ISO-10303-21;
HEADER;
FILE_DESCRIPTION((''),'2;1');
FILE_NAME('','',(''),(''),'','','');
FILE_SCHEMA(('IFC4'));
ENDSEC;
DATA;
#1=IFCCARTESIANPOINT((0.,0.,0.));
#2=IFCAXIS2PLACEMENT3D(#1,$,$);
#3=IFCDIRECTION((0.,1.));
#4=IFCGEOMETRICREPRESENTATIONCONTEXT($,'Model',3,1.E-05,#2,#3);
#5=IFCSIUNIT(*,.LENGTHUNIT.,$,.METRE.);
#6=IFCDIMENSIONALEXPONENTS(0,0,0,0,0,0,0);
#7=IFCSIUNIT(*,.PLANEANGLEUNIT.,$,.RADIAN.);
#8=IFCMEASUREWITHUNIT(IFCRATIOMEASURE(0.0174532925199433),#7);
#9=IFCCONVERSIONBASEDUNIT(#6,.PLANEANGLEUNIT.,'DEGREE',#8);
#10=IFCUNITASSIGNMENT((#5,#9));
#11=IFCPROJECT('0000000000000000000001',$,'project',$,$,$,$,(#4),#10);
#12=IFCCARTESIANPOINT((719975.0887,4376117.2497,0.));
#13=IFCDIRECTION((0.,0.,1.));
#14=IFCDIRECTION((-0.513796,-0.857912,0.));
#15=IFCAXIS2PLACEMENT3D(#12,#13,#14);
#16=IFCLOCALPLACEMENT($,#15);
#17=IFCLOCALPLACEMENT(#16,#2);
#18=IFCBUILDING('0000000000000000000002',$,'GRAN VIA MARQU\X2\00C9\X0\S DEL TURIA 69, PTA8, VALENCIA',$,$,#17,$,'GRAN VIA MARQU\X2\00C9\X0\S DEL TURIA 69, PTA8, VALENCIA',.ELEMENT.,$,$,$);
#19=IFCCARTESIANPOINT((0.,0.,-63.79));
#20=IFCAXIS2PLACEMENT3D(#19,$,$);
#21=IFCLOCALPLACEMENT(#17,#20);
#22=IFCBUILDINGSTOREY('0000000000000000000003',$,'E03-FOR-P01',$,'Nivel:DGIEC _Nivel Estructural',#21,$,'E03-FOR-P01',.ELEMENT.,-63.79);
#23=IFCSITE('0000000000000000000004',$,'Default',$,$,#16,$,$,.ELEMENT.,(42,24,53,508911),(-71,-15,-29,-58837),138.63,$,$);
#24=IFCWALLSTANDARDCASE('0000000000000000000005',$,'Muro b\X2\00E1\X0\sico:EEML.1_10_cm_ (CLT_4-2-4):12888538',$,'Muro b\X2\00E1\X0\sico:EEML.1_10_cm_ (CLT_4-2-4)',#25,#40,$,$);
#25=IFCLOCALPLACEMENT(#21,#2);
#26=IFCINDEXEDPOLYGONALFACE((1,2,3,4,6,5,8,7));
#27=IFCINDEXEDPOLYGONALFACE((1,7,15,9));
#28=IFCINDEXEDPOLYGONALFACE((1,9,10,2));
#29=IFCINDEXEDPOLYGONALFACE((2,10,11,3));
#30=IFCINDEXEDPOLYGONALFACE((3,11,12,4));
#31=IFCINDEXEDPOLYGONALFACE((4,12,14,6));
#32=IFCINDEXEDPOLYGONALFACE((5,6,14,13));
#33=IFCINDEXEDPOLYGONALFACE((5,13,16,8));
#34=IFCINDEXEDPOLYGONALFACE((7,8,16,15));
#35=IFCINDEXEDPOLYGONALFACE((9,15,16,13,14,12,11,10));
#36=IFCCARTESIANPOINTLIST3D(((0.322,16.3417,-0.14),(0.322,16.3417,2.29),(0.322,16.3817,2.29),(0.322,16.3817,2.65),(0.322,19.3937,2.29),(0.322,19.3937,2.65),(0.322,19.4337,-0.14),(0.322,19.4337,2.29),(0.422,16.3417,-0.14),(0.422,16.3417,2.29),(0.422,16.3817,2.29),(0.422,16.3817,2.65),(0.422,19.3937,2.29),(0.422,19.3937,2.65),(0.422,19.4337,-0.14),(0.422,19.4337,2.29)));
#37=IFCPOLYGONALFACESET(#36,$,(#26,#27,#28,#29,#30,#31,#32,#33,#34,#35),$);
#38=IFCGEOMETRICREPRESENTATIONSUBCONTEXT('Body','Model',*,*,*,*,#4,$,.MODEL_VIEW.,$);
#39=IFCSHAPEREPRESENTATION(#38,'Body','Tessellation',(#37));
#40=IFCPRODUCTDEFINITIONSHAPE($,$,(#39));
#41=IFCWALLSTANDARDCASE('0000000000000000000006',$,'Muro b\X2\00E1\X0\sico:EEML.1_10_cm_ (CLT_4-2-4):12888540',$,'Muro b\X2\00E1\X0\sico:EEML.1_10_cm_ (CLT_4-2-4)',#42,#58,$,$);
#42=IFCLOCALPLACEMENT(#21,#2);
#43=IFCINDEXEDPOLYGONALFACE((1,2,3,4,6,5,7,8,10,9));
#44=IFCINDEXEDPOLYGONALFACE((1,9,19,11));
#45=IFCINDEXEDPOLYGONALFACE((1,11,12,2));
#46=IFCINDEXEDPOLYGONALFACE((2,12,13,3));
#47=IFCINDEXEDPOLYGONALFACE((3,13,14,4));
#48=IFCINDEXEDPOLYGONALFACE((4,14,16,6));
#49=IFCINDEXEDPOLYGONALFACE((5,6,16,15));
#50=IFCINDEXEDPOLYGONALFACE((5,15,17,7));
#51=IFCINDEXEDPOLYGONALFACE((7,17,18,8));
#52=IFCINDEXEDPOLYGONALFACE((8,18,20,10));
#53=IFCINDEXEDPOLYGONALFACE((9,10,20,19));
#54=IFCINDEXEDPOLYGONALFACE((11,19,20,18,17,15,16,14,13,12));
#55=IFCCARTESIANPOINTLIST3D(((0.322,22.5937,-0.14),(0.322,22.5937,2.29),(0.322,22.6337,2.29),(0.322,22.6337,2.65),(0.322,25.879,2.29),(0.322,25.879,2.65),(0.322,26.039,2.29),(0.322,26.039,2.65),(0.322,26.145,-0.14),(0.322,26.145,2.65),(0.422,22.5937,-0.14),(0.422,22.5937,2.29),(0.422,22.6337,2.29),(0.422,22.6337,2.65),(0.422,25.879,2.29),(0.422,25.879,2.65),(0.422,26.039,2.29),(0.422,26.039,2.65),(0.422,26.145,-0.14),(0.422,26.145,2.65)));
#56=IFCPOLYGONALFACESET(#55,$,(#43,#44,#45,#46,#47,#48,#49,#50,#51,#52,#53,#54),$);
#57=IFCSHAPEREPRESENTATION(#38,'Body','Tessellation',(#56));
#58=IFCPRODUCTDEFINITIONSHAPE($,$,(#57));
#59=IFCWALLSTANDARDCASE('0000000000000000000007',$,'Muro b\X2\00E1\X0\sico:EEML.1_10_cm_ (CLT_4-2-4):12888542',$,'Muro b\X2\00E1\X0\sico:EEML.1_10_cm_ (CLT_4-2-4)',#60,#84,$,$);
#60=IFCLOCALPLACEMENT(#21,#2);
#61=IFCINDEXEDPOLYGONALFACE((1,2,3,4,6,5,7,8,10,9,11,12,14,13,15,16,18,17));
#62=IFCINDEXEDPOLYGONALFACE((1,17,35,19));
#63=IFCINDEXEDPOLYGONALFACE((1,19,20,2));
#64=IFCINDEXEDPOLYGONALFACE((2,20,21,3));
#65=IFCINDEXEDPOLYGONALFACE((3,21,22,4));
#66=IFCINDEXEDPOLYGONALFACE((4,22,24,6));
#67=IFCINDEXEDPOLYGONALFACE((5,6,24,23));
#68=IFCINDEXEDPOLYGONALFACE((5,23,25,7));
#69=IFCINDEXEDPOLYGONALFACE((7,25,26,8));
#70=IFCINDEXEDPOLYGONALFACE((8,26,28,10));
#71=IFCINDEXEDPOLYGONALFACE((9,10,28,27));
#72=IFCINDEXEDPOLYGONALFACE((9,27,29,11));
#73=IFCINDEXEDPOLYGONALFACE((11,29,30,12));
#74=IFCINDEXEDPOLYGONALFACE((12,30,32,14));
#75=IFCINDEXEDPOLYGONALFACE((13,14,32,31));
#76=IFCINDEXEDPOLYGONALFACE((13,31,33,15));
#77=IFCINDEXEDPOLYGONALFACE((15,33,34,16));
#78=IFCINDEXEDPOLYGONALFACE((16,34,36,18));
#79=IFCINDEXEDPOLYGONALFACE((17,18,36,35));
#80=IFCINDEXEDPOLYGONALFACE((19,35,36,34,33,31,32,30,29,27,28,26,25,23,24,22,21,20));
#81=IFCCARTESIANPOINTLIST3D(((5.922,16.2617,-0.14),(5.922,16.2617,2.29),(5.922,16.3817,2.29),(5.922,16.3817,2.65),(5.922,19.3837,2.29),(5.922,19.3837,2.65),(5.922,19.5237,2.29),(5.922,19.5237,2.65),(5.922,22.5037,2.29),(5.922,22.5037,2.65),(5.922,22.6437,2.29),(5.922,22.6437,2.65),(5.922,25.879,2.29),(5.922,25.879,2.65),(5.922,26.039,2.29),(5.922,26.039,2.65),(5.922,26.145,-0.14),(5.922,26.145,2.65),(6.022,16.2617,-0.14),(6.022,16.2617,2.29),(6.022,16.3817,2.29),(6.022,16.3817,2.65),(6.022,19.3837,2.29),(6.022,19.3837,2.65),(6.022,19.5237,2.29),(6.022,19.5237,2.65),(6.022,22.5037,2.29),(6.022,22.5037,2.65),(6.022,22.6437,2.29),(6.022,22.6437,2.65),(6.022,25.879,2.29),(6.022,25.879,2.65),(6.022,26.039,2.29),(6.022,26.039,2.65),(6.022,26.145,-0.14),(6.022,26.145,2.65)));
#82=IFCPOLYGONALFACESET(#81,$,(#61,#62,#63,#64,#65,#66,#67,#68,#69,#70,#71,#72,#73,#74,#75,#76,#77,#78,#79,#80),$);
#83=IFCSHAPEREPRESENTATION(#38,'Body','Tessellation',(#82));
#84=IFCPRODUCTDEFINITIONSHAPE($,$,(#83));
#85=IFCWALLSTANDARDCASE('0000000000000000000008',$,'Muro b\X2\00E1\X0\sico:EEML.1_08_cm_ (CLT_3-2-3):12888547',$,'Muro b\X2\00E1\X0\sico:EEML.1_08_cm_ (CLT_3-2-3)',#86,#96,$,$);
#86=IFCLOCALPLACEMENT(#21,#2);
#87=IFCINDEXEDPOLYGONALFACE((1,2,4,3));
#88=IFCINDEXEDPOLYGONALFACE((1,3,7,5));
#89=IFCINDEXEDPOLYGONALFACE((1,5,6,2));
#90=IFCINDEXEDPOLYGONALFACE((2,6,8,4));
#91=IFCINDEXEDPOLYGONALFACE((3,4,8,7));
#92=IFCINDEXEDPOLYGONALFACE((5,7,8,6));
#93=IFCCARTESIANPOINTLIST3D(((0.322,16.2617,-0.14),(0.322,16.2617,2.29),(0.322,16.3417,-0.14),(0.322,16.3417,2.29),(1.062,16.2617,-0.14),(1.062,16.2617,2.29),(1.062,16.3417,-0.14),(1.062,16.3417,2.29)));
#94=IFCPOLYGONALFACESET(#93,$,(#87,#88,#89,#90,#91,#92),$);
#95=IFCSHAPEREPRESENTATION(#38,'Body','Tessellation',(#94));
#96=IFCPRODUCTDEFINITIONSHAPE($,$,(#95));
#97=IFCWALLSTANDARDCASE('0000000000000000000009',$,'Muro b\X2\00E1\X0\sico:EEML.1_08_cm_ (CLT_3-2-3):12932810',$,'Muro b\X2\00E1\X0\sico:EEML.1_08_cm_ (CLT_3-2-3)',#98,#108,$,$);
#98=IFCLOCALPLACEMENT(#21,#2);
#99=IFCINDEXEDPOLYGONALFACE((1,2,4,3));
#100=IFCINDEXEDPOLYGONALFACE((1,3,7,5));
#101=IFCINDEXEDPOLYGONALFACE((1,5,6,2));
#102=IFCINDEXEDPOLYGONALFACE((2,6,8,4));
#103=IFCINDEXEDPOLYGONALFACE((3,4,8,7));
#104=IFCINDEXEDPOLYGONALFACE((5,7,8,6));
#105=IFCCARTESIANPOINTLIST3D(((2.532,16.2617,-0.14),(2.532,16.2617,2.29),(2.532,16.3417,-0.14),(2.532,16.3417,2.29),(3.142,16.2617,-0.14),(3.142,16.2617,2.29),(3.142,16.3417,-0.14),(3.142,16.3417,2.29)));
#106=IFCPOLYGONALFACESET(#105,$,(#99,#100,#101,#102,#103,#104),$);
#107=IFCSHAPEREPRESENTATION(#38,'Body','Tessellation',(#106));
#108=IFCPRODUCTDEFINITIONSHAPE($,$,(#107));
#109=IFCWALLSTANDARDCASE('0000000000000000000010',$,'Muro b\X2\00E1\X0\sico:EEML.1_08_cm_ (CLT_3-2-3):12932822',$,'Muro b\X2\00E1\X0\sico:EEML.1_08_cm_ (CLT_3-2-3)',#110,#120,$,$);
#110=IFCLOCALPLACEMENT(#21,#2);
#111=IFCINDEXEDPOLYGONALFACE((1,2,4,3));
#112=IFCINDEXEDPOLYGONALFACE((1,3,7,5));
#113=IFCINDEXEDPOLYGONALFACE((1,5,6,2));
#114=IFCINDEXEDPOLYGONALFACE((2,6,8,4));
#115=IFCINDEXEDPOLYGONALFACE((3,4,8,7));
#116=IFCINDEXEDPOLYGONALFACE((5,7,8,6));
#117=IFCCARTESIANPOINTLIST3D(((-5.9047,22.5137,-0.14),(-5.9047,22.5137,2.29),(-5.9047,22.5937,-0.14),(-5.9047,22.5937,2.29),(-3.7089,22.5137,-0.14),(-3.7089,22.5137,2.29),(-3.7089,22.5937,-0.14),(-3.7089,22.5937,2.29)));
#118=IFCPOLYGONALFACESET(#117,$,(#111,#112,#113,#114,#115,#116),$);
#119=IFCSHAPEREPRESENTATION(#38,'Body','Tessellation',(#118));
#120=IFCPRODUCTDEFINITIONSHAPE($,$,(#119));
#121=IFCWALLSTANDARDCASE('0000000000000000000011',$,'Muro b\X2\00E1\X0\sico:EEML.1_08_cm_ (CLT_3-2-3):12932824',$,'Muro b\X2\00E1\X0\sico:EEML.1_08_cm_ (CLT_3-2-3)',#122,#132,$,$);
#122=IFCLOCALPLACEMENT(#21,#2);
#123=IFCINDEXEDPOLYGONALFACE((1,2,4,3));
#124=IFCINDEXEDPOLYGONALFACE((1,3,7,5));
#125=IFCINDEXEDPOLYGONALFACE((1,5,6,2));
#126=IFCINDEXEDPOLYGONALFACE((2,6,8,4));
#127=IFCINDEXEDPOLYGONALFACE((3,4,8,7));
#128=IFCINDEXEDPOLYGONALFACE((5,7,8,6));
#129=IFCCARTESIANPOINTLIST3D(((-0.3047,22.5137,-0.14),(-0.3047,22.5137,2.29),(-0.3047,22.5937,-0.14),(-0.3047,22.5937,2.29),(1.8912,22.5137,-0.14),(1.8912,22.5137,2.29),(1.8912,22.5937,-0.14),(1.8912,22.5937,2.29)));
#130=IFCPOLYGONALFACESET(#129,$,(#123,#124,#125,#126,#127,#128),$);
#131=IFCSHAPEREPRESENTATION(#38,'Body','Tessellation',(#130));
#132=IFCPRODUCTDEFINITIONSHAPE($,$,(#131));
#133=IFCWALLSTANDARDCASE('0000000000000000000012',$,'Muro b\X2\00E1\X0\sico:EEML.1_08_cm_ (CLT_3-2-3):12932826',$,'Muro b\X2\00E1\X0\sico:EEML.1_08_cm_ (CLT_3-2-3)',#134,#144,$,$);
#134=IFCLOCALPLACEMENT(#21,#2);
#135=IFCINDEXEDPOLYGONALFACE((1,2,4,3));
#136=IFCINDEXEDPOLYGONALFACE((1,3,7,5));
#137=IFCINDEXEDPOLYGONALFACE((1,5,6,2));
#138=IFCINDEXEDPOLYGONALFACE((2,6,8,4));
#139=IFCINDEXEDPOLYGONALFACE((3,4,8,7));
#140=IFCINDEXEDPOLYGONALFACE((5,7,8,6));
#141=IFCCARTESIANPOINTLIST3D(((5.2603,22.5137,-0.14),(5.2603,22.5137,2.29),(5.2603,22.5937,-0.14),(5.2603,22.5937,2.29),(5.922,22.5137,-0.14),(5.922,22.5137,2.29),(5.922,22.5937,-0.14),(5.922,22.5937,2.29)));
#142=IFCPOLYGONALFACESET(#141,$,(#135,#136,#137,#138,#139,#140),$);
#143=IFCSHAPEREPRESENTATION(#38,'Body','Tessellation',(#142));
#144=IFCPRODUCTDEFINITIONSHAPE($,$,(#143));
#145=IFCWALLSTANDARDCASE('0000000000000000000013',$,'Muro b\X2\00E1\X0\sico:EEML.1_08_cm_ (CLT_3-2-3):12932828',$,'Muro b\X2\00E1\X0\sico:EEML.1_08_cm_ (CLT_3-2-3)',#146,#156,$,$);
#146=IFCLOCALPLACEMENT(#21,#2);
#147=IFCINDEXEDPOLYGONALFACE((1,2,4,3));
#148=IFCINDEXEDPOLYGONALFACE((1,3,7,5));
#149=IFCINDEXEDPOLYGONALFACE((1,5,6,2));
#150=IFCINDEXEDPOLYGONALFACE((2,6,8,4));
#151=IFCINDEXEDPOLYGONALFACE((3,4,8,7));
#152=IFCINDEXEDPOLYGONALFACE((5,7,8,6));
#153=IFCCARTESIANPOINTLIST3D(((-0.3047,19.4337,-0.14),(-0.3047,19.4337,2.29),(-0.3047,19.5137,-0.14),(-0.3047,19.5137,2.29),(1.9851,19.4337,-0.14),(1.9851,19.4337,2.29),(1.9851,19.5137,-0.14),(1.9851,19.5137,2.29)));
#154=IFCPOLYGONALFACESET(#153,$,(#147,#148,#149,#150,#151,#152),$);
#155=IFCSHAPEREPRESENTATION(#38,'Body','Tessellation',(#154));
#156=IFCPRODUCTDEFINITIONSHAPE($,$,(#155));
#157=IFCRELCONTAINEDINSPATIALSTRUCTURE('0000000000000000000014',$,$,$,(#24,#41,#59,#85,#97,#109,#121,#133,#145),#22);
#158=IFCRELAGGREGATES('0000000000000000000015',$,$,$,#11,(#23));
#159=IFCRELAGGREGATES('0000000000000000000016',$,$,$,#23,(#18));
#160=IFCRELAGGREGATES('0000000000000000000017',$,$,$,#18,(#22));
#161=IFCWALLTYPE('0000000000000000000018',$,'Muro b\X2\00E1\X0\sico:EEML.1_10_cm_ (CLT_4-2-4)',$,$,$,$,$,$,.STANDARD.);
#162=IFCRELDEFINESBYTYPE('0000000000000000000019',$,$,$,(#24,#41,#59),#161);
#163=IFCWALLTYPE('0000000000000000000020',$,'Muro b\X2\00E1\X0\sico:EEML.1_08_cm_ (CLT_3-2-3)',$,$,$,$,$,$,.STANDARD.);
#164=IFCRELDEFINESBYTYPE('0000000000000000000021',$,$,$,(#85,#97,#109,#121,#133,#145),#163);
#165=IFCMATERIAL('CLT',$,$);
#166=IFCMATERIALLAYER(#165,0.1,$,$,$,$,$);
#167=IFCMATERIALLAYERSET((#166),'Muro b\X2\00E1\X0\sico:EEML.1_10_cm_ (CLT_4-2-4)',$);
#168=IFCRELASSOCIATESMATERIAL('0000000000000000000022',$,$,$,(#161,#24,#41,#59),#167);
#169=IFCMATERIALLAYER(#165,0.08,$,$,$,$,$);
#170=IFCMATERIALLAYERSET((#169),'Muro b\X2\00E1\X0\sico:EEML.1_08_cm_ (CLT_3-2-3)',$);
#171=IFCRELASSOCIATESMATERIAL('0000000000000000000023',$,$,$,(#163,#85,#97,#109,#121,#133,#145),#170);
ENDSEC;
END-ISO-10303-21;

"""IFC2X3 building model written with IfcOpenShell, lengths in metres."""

from ifc_helpers import new_model, entity, si_unit, converted_unit, direction, frame, frame_2d, origin, place, context, subcontext, project, spatial, rectangle, extrude, material, layer, layer_set, layer_usage, type_object, element, save


model = new_model("IFC2X3")

# Units and contexts
model_context = context("Model", 3, precision=1e-05, world=origin(), true_north=direction((0.0, 1.0)))
body_context = subcontext(model_context, "Body", "Model", "MODEL_VIEW")
ifc_project = project(units=[si_unit("LENGTHUNIT", "METRE"), converted_unit("PLANEANGLEUNIT", "DEGREE", entity("IfcRatioMeasure", 0.0174532925199433), si_unit("PLANEANGLEUNIT", "RADIAN"), dimensions=[0, 0, 0, 0, 0, 0, 0])], contexts=[model_context])

# Site, building, storey
site_placement = place(None, frame((719975.0887, 4376117.2497, 0.0), z_axis=(0.0, 0.0, 1.0), x_axis=(-0.513796, -0.857912, 0.0)))
site = spatial("IfcSite", under=ifc_project, at=site_placement, Name="Default", CompositionType="ELEMENT", RefLatitude=(42, 24, 53, 508911), RefLongitude=(-71, -15, -29, -58837), RefElevation=138.63)
building_placement = place(site_placement, origin())
building = spatial("IfcBuilding", under=site, at=building_placement, Name="GRAN VIA MARQUÉS DEL TURIA 69, PTA8, VALENCIA", LongName="GRAN VIA MARQUÉS DEL TURIA 69, PTA8, VALENCIA", CompositionType="ELEMENT")
storey_placement = place(building_placement, frame((0.0, 0.0, -63.79)))
storey = spatial("IfcBuildingStorey", under=building, at=storey_placement, Name="E03-FOR-P01", ObjectType="Nivel:DGIEC _Nivel Estructural", LongName="E03-FOR-P01", CompositionType="ELEMENT", Elevation=-63.79)

# Walls, openings
ifc_material = material(Name="CLT")
ifc_layer_1 = layer(ifc_material, 0.1)
ifc_layer_set_1 = layer_set([ifc_layer_1], Name="Muro básico:EEML.1_10_cm_ (CLT_4-2-4)")
ifc_layer_usage_1 = layer_usage(ifc_layer_set_1, "AXIS2", "NEGATIVE", 0.05)
wall_type_1 = type_object("IfcWallType", Name="Muro básico:EEML.1_10_cm_ (CLT_4-2-4)", PredefinedType="STANDARD", material=ifc_layer_set_1)
wall_1_placement = place(storey_placement, frame((0.372, 16.3417, -0.14), z_axis=(0.0, 0.0, 1.0), x_axis=(0.0, 1.0, 0.0)))
wall_1 = element("IfcWallStandardCase", 1, at=wall_1_placement, inside=storey, type_object=wall_type_1, material=ifc_layer_usage_1, Name="Muro básico:EEML.1_10_cm_ (CLT_4-2-4):12888538", ObjectType="Muro básico:EEML.1_10_cm_ (CLT_4-2-4)", context=body_context, shape_type="SweptSolid", body=[
    extrude(rectangle(XDim=3.092, YDim=0.1, at=frame_2d((1.546, 0.0), x_axis=(-1.0, 0.0))), origin(), (0.0, 0.0, 1.0), 2.79),
])
opening_1_placement = place(wall_1_placement, origin())
element("IfcOpeningElement", 2, at=opening_1_placement, cuts=wall_1, ObjectType="Opening", context=body_context, shape_type="SweptSolid", body=[
    extrude(rectangle(XDim=0.36, YDim=0.08, at=frame_2d((0.0, 0.0), x_axis=(1.0, 0.0))), frame((3.092, 0.05, 2.61), z_axis=(0.0, -1.0, 0.0), x_axis=(0.0, 0.0, 1.0)), (0.0, 0.0, 1.0), 0.1),
])
opening_2_placement = place(wall_1_placement, origin())
element("IfcOpeningElement", 3, at=opening_2_placement, cuts=wall_1, ObjectType="Opening", context=body_context, shape_type="SweptSolid", body=[
    extrude(rectangle(XDim=0.36, YDim=0.08, at=frame_2d((0.0, 0.0), x_axis=(0.0, 1.0))), frame((0.0, 0.05, 2.61), z_axis=(0.0, -1.0, 0.0), x_axis=(-1.0, 0.0, 0.0)), (0.0, 0.0, 1.0), 0.1),
])
ifc_layer_usage_2 = layer_usage(ifc_layer_set_1, "AXIS2", "NEGATIVE", 0.05)
wall_2_placement = place(storey_placement, frame((0.372, 22.5937, -0.14), z_axis=(0.0, 0.0, 1.0), x_axis=(0.0, 1.0, 0.0)))
wall_2 = element("IfcWallStandardCase", 4, at=wall_2_placement, inside=storey, type_object=wall_type_1, material=ifc_layer_usage_2, Name="Muro básico:EEML.1_10_cm_ (CLT_4-2-4):12888540", ObjectType="Muro básico:EEML.1_10_cm_ (CLT_4-2-4)", context=body_context, shape_type="SweptSolid", body=[
    extrude(rectangle(XDim=3.5513, YDim=0.1, at=frame_2d((1.7757, 0.0), x_axis=(-1.0, 0.0))), origin(), (0.0, 0.0, 1.0), 2.79),
])
opening_3_placement = place(wall_2_placement, origin())
element("IfcOpeningElement", 5, at=opening_3_placement, cuts=wall_2, ObjectType="Opening", context=body_context, shape_type="SweptSolid", body=[
    extrude(rectangle(XDim=0.36, YDim=0.16, at=frame_2d((0.0, 0.0), x_axis=(0.0, 1.0))), frame((3.3653, 0.05, 2.61), z_axis=(0.0, -1.0, 0.0), x_axis=(-1.0, 0.0, 0.0)), (0.0, 0.0, 1.0), 0.1),
])
opening_4_placement = place(wall_2_placement, origin())
element("IfcOpeningElement", 6, at=opening_4_placement, cuts=wall_2, ObjectType="Opening", context=body_context, shape_type="SweptSolid", body=[
    extrude(rectangle(XDim=0.36, YDim=0.08, at=frame_2d((0.0, 0.0), x_axis=(0.0, 1.0))), frame((0.0, 0.05, 2.61), z_axis=(0.0, -1.0, 0.0), x_axis=(-1.0, 0.0, 0.0)), (0.0, 0.0, 1.0), 0.1),
])
ifc_layer_usage_3 = layer_usage(ifc_layer_set_1, "AXIS2", "NEGATIVE", 0.05)
wall_3_placement = place(storey_placement, frame((5.972, 16.2617, -0.14), z_axis=(0.0, 0.0, 1.0), x_axis=(0.0, 1.0, 0.0)))
wall_3 = element("IfcWallStandardCase", 7, at=wall_3_placement, inside=storey, type_object=wall_type_1, material=ifc_layer_usage_3, Name="Muro básico:EEML.1_10_cm_ (CLT_4-2-4):12888542", ObjectType="Muro básico:EEML.1_10_cm_ (CLT_4-2-4)", context=body_context, shape_type="SweptSolid", body=[
    extrude(rectangle(XDim=9.8833, YDim=0.1, at=frame_2d((4.9417, 0.0), x_axis=(-1.0, 0.0))), origin(), (0.0, 0.0, 1.0), 2.79),
])
opening_5_placement = place(wall_3_placement, origin())
element("IfcOpeningElement", 8, at=opening_5_placement, cuts=wall_3, ObjectType="Opening", context=body_context, shape_type="SweptSolid", body=[
    extrude(rectangle(XDim=0.36, YDim=0.16, at=frame_2d((0.0, 0.0), x_axis=(0.0, 1.0))), frame((9.6973, 0.05, 2.61), z_axis=(0.0, -1.0, 0.0), x_axis=(-1.0, 0.0, 0.0)), (0.0, 0.0, 1.0), 0.1),
])
opening_6_placement = place(wall_3_placement, origin())
element("IfcOpeningElement", 9, at=opening_6_placement, cuts=wall_3, ObjectType="Opening", context=body_context, shape_type="SweptSolid", body=[
    extrude(rectangle(XDim=0.36, YDim=0.14, at=frame_2d((0.0, 0.0), x_axis=(0.0, 1.0))), frame((6.312, 0.05, 2.61), z_axis=(0.0, -1.0, 0.0), x_axis=(-1.0, 0.0, 0.0)), (0.0, 0.0, 1.0), 0.1),
])
opening_7_placement = place(wall_3_placement, origin())
element("IfcOpeningElement", 10, at=opening_7_placement, cuts=wall_3, ObjectType="Opening", context=body_context, shape_type="SweptSolid", body=[
    extrude(rectangle(XDim=0.36, YDim=0.14, at=frame_2d((0.0, 0.0), x_axis=(0.0, 1.0))), frame((3.192, 0.05, 2.61), z_axis=(0.0, -1.0, 0.0), x_axis=(-1.0, 0.0, 0.0)), (0.0, 0.0, 1.0), 0.1),
])
opening_8_placement = place(wall_3_placement, origin())
element("IfcOpeningElement", 11, at=opening_8_placement, cuts=wall_3, ObjectType="Opening", context=body_context, shape_type="SweptSolid", body=[
    extrude(rectangle(XDim=0.36, YDim=0.12, at=frame_2d((0.0, 0.0), x_axis=(0.0, 1.0))), frame((0.06, 0.05, 2.61), z_axis=(0.0, -1.0, 0.0), x_axis=(-1.0, 0.0, 0.0)), (0.0, 0.0, 1.0), 0.1),
])

# Walls
ifc_layer_2 = layer(ifc_material, 0.08)
ifc_layer_set_2 = layer_set([ifc_layer_2], Name="Muro básico:EEML.1_08_cm_ (CLT_3-2-3)")
ifc_layer_usage_4 = layer_usage(ifc_layer_set_2, "AXIS2", "NEGATIVE", 0.04)
wall_type_2 = type_object("IfcWallType", Name="Muro básico:EEML.1_08_cm_ (CLT_3-2-3)", PredefinedType="STANDARD", material=ifc_layer_set_2)
wall_4_placement = place(storey_placement, frame((1.062, 16.3017, -0.14), z_axis=(0.0, 0.0, 1.0), x_axis=(-1.0, 0.0, 0.0)))
element("IfcWallStandardCase", 12, at=wall_4_placement, inside=storey, type_object=wall_type_2, material=ifc_layer_usage_4, Name="Muro básico:EEML.1_08_cm_ (CLT_3-2-3):12888547", ObjectType="Muro básico:EEML.1_08_cm_ (CLT_3-2-3)", context=body_context, shape_type="SweptSolid", body=[
    extrude(rectangle(XDim=0.74, YDim=0.08, at=frame_2d((0.37, 0.0), x_axis=(-1.0, 0.0))), origin(), (0.0, 0.0, 1.0), 2.43),
])
ifc_layer_usage_5 = layer_usage(ifc_layer_set_2, "AXIS2", "NEGATIVE", 0.04)
wall_5_placement = place(storey_placement, frame((3.142, 16.3017, -0.14), z_axis=(0.0, 0.0, 1.0), x_axis=(-1.0, 0.0, 0.0)))
element("IfcWallStandardCase", 13, at=wall_5_placement, inside=storey, type_object=wall_type_2, material=ifc_layer_usage_5, Name="Muro básico:EEML.1_08_cm_ (CLT_3-2-3):12932810", ObjectType="Muro básico:EEML.1_08_cm_ (CLT_3-2-3)", context=body_context, shape_type="SweptSolid", body=[
    extrude(rectangle(XDim=0.61, YDim=0.08, at=frame_2d((0.305, 0.0), x_axis=(-1.0, 0.0))), origin(), (0.0, 0.0, 1.0), 2.43),
])
ifc_layer_usage_6 = layer_usage(ifc_layer_set_2, "AXIS2", "NEGATIVE", 0.04)
wall_6_placement = place(storey_placement, frame((-3.7089, 22.5537, -0.14), z_axis=(0.0, 0.0, 1.0), x_axis=(-1.0, 0.0, 0.0)))
element("IfcWallStandardCase", 14, at=wall_6_placement, inside=storey, type_object=wall_type_2, material=ifc_layer_usage_6, Name="Muro básico:EEML.1_08_cm_ (CLT_3-2-3):12932822", ObjectType="Muro básico:EEML.1_08_cm_ (CLT_3-2-3)", context=body_context, shape_type="SweptSolid", body=[
    extrude(rectangle(XDim=2.1959, YDim=0.08, at=frame_2d((1.0979, 0.0), x_axis=(-1.0, 0.0))), origin(), (0.0, 0.0, 1.0), 2.43),
])
ifc_layer_usage_7 = layer_usage(ifc_layer_set_2, "AXIS2", "NEGATIVE", 0.04)
wall_7_placement = place(storey_placement, frame((1.8912, 22.5537, -0.14), z_axis=(0.0, 0.0, 1.0), x_axis=(-1.0, 0.0, 0.0)))
element("IfcWallStandardCase", 15, at=wall_7_placement, inside=storey, type_object=wall_type_2, material=ifc_layer_usage_7, Name="Muro básico:EEML.1_08_cm_ (CLT_3-2-3):12932824", ObjectType="Muro básico:EEML.1_08_cm_ (CLT_3-2-3)", context=body_context, shape_type="SweptSolid", body=[
    extrude(rectangle(XDim=2.1959, YDim=0.08, at=frame_2d((1.0979, 0.0), x_axis=(-1.0, 0.0))), origin(), (0.0, 0.0, 1.0), 2.43),
])
ifc_layer_usage_8 = layer_usage(ifc_layer_set_2, "AXIS2", "NEGATIVE", 0.04)
wall_8_placement = place(storey_placement, frame((5.922, 22.5537, -0.14), z_axis=(0.0, 0.0, 1.0), x_axis=(-1.0, 0.0, 0.0)))
element("IfcWallStandardCase", 16, at=wall_8_placement, inside=storey, type_object=wall_type_2, material=ifc_layer_usage_8, Name="Muro básico:EEML.1_08_cm_ (CLT_3-2-3):12932826", ObjectType="Muro básico:EEML.1_08_cm_ (CLT_3-2-3)", context=body_context, shape_type="SweptSolid", body=[
    extrude(rectangle(XDim=0.6617, YDim=0.08, at=frame_2d((0.3308, 0.0), x_axis=(-1.0, 0.0))), origin(), (0.0, 0.0, 1.0), 2.43),
])
ifc_layer_usage_9 = layer_usage(ifc_layer_set_2, "AXIS2", "NEGATIVE", 0.04)
wall_9_placement = place(storey_placement, frame((1.9851, 19.4737, -0.14), z_axis=(0.0, 0.0, 1.0), x_axis=(-1.0, 0.0, 0.0)))
element("IfcWallStandardCase", 17, at=wall_9_placement, inside=storey, type_object=wall_type_2, material=ifc_layer_usage_9, Name="Muro básico:EEML.1_08_cm_ (CLT_3-2-3):12932828", ObjectType="Muro básico:EEML.1_08_cm_ (CLT_3-2-3)", context=body_context, shape_type="SweptSolid", body=[
    extrude(rectangle(XDim=2.2898, YDim=0.08, at=frame_2d((1.1449, 0.0), x_axis=(-1.0, 0.0))), origin(), (0.0, 0.0, 1.0), 2.43),
])

save(model, "model.ifc")
